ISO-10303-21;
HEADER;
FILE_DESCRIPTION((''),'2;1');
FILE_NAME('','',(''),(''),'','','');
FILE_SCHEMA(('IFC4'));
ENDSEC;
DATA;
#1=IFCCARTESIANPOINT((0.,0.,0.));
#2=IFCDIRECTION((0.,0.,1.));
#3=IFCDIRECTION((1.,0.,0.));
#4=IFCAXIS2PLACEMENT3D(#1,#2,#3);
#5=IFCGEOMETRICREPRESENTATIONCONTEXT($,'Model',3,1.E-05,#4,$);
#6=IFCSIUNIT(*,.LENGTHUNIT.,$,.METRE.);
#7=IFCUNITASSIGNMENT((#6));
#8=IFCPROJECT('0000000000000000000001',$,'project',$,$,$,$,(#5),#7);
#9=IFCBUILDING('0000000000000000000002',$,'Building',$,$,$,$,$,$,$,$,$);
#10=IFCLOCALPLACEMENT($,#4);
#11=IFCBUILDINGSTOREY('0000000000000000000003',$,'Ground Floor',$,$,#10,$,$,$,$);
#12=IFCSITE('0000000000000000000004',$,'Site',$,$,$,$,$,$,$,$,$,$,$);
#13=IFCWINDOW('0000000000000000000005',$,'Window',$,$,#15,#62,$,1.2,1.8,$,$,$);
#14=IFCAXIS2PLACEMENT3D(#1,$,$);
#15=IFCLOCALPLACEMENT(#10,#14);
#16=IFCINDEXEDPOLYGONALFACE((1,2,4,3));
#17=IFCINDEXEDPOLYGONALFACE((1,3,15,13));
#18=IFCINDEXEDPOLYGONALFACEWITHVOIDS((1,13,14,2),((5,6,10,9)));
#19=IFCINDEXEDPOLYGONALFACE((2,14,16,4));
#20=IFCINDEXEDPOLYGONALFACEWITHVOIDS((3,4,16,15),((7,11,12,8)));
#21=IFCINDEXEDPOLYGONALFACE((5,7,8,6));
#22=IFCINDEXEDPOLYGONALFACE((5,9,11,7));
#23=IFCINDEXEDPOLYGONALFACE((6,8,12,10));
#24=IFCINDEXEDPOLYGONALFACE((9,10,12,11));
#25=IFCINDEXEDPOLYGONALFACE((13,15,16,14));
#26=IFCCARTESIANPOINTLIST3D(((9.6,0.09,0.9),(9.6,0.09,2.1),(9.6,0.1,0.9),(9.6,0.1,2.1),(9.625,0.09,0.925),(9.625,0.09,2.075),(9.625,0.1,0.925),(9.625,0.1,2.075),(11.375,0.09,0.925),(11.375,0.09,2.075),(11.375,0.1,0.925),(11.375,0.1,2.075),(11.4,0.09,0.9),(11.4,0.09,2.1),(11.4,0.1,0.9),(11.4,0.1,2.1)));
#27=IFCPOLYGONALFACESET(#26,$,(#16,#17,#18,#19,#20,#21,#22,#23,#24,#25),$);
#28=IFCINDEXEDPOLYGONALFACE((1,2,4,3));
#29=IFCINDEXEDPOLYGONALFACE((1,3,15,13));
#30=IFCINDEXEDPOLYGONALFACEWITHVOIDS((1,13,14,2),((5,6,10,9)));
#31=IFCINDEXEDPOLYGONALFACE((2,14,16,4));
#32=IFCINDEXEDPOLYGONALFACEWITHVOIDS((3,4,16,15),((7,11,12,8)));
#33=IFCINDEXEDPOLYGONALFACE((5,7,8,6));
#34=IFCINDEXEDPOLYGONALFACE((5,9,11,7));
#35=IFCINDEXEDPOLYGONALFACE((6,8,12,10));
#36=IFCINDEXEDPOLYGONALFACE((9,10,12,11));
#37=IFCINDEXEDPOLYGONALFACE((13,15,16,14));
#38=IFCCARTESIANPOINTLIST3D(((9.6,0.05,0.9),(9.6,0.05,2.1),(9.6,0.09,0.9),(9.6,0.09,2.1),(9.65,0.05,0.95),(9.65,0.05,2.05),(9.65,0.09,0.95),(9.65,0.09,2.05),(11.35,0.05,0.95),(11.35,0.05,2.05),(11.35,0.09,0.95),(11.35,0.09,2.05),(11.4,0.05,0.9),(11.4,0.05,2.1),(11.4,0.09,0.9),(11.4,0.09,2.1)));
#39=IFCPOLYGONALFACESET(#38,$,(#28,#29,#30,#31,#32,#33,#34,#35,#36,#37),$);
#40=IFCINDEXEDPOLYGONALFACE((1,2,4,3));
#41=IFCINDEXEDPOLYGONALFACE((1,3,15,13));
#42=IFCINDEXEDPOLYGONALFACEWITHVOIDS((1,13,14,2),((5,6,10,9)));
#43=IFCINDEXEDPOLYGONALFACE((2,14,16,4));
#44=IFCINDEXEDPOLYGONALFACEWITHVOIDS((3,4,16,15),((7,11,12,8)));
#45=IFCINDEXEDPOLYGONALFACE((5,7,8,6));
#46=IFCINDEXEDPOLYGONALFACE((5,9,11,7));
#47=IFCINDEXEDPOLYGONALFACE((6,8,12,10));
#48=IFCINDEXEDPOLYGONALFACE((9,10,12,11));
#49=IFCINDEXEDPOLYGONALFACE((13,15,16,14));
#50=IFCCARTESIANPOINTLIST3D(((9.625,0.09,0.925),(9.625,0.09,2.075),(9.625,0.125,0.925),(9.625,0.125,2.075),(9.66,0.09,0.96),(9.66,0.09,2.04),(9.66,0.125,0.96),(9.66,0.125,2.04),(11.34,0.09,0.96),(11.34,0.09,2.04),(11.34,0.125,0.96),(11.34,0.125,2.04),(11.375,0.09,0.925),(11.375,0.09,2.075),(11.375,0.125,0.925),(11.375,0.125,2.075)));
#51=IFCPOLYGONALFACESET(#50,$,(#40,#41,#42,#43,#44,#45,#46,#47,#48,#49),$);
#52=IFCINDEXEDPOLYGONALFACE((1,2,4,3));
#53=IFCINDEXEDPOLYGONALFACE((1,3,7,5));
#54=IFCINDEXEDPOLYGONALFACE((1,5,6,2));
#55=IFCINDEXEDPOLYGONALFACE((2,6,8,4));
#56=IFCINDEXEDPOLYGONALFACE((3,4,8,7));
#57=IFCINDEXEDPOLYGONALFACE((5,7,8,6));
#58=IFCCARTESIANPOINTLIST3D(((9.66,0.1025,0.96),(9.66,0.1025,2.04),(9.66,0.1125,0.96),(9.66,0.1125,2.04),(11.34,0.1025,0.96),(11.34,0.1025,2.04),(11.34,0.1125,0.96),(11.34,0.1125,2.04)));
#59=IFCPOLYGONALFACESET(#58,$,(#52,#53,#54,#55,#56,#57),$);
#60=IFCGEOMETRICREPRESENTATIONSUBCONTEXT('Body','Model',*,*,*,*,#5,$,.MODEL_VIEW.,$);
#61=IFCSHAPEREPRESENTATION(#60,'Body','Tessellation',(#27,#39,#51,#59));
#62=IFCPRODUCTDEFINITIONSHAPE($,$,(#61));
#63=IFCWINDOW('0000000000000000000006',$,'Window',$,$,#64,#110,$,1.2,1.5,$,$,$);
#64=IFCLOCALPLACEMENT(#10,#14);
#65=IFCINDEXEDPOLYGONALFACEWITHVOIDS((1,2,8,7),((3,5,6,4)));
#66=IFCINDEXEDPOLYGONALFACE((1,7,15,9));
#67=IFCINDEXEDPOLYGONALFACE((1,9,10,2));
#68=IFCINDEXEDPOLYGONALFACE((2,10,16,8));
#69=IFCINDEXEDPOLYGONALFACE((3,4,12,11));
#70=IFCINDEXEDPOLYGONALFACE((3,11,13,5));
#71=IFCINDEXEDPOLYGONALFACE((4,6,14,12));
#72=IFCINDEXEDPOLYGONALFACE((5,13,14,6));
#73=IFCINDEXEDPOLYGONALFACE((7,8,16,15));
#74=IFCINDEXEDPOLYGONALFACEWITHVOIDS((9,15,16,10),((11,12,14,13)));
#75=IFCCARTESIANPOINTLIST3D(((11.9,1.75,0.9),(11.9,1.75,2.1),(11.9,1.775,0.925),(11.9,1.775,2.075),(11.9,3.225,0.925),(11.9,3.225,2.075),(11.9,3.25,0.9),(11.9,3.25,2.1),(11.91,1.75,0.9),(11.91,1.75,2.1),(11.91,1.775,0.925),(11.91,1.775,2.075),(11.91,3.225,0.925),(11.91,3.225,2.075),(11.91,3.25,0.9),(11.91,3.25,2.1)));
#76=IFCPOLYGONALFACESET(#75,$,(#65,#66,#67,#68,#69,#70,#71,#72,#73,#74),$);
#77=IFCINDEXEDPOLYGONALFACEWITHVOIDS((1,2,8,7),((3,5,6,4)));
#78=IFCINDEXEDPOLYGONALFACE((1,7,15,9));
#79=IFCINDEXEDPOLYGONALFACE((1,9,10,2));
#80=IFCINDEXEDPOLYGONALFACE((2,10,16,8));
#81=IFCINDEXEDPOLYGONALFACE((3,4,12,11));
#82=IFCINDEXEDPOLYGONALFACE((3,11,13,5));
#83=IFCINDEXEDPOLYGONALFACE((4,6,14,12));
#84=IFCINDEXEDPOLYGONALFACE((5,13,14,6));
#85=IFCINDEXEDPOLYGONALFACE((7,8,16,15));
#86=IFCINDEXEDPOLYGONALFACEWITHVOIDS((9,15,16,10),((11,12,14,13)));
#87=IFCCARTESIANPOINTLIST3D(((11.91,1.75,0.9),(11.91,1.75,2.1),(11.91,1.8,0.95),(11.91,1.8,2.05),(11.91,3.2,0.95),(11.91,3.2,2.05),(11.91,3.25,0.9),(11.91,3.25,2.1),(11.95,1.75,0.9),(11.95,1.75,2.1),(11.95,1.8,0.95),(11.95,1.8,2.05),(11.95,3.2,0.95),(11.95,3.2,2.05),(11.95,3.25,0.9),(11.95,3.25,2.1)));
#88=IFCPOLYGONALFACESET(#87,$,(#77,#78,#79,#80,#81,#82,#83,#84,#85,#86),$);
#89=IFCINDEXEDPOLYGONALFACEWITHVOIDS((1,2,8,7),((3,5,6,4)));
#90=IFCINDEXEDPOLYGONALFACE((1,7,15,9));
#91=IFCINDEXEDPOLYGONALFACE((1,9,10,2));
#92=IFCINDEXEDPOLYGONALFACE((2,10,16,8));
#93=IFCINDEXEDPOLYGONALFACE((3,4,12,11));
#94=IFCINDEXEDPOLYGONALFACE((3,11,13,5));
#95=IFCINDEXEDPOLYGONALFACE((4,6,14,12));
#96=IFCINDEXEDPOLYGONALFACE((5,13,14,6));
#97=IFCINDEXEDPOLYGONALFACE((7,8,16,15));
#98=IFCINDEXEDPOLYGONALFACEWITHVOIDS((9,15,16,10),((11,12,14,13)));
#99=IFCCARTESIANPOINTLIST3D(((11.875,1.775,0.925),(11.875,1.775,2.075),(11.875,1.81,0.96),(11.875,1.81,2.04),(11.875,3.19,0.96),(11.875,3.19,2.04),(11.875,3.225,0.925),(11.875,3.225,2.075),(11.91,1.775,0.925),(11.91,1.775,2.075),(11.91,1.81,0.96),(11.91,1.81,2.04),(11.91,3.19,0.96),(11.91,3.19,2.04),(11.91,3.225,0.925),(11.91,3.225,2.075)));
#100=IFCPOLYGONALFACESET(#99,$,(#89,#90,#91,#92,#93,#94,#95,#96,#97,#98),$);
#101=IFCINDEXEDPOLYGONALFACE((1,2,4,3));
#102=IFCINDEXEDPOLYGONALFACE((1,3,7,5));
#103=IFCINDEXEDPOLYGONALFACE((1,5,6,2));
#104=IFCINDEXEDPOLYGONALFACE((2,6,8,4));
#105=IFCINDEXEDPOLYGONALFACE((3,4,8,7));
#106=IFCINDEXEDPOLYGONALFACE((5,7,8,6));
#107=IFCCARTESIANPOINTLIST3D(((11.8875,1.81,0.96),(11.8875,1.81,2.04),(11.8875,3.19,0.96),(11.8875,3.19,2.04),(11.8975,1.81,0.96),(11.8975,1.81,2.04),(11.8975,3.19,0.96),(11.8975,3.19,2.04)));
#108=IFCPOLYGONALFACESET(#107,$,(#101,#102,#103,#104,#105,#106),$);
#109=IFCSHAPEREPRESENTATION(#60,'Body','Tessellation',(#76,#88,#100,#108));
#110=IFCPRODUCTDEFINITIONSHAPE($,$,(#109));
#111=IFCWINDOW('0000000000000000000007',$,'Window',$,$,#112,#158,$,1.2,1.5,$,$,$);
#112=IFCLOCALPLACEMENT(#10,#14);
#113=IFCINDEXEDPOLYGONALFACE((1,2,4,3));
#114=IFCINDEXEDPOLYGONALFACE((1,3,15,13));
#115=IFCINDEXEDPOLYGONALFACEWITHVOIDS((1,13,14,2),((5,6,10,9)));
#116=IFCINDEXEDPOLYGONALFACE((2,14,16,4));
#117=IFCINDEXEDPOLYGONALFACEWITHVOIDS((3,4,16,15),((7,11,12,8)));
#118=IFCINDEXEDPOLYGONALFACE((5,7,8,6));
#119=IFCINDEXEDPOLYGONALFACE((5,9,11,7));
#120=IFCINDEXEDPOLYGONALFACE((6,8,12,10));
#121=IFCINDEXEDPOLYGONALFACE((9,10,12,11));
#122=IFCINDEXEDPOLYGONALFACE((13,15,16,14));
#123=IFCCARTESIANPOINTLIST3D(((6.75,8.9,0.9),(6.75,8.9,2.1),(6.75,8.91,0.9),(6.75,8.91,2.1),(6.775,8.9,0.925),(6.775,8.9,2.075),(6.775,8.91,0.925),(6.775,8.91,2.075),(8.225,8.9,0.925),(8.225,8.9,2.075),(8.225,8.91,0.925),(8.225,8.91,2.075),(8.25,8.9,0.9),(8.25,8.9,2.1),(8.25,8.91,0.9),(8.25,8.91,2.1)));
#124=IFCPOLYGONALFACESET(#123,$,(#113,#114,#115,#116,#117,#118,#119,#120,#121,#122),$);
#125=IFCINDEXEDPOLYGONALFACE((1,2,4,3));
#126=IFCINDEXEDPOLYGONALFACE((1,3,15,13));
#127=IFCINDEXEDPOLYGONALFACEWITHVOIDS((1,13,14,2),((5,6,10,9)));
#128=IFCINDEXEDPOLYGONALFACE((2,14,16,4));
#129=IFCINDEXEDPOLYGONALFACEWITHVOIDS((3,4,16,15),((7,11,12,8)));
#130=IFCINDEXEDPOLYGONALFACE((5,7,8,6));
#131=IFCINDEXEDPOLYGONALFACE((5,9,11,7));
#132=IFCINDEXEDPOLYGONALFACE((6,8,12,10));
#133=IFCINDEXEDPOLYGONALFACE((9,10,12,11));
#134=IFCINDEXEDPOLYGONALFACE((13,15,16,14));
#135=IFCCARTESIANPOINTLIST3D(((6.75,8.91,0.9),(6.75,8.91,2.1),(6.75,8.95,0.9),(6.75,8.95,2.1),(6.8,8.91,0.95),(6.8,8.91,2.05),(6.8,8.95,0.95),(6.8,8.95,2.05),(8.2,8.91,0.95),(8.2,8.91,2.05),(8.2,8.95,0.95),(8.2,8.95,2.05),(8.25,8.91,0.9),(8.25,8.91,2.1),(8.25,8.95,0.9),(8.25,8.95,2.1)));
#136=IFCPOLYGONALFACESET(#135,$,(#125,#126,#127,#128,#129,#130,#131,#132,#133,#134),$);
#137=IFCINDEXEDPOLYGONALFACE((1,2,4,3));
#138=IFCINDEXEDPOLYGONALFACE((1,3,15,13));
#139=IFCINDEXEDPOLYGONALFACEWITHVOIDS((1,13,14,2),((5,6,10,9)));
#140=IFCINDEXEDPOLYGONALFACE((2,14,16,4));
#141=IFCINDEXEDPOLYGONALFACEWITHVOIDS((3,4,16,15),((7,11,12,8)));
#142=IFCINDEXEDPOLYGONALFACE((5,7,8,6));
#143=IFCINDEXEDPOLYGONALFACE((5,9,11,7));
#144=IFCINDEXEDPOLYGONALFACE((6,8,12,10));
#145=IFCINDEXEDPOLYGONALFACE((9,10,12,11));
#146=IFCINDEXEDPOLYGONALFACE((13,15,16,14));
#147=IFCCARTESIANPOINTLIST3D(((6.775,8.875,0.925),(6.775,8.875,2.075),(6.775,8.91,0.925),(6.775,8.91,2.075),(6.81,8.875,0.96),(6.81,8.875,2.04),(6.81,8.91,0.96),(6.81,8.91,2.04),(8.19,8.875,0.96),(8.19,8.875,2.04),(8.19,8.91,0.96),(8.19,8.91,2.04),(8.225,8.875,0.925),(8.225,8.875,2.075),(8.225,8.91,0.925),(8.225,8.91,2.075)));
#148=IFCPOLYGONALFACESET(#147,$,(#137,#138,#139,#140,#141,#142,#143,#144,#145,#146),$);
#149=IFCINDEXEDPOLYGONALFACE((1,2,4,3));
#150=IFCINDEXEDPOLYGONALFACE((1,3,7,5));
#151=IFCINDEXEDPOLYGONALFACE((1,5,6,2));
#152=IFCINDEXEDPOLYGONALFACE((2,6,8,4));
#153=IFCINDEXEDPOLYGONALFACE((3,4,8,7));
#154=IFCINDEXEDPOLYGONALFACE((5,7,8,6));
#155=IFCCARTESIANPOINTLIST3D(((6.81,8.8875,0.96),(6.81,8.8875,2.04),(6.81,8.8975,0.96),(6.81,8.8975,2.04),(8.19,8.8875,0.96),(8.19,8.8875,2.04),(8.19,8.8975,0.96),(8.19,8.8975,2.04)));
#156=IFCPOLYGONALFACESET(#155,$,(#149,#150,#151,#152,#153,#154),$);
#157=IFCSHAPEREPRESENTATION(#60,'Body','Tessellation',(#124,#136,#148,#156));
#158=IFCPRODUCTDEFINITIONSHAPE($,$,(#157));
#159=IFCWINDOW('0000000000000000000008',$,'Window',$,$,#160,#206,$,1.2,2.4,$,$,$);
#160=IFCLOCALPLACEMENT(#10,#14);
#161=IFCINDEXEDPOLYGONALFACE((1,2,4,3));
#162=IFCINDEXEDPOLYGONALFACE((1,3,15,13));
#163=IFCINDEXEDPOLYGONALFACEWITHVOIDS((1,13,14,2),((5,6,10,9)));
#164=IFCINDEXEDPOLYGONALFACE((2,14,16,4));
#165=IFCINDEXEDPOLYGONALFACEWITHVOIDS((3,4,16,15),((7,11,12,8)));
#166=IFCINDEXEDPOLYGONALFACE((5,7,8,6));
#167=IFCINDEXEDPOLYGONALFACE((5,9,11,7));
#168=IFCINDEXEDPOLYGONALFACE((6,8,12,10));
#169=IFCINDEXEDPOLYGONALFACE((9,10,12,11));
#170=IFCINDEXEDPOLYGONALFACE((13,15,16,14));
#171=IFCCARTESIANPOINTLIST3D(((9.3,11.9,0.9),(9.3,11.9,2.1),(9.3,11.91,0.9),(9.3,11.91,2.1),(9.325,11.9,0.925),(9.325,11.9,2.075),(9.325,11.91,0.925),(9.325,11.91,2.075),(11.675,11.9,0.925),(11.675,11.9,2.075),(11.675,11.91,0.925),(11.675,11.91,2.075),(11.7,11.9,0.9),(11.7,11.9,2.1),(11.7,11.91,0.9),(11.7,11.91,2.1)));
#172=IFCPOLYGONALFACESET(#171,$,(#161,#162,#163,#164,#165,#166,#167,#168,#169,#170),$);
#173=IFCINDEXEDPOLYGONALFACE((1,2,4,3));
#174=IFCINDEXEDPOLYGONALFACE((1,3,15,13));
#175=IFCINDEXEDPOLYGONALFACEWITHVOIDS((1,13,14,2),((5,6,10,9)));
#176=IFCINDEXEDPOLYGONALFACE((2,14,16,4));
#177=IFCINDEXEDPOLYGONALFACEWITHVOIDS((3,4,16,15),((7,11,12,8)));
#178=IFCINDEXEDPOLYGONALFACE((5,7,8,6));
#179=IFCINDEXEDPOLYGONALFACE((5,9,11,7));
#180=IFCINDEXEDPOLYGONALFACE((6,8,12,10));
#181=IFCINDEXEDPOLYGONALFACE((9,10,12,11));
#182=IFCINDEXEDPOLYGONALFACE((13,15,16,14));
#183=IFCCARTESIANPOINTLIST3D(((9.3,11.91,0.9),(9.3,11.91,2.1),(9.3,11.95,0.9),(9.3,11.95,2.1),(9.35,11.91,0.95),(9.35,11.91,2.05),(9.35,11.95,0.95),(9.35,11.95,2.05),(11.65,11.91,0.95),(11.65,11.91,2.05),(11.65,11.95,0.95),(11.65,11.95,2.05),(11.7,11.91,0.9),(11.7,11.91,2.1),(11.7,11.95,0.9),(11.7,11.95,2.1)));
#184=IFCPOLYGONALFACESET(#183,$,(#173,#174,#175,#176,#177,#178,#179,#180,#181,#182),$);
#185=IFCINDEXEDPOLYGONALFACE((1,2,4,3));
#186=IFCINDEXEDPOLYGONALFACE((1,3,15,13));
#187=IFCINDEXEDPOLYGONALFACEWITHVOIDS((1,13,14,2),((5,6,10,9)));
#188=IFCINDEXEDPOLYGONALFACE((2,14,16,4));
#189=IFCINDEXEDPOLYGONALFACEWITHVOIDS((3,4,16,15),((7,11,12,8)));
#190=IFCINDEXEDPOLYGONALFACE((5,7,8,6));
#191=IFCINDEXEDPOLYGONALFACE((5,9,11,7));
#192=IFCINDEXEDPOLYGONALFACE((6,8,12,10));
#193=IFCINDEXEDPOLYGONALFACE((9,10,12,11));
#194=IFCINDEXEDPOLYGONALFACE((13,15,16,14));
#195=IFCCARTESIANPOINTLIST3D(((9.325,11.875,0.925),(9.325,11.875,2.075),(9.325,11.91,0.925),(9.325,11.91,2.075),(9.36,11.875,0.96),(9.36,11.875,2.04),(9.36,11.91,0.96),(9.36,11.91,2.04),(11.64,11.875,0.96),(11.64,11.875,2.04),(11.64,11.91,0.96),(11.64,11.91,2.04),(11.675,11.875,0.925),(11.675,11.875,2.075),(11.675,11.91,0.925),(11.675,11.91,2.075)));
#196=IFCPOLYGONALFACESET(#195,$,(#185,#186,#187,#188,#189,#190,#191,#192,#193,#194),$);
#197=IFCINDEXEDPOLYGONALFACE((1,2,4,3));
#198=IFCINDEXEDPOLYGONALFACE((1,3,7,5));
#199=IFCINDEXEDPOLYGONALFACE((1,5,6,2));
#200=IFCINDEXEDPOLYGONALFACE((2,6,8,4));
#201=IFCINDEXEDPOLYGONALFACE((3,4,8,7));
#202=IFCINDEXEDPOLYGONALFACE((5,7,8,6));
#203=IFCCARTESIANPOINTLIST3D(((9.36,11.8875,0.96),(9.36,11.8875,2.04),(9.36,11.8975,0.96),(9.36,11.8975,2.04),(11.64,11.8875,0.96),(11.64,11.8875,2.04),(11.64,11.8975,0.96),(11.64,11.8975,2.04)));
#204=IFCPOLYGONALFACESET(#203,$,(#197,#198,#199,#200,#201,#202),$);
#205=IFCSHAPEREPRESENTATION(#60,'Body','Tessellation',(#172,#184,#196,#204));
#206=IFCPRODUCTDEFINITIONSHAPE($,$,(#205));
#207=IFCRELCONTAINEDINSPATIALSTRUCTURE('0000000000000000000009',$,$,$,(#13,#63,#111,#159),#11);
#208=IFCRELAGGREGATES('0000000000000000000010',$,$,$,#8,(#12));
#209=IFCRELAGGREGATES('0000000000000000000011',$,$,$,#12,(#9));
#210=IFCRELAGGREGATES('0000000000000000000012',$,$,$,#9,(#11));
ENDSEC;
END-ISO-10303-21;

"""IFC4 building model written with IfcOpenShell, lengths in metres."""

from ifc_helpers import new_model, si_unit, frame, origin_with_axes, place, context, subcontext, project, spatial, line, indexed_curve, outline, extrude, element, save


model = new_model("IFC4")

# Units and contexts
model_context = context("Model", 3, precision=1e-05, world=origin_with_axes())
body_context = subcontext(model_context, "Body", "Model", "MODEL_VIEW")
ifc_project = project(units=[si_unit("LENGTHUNIT", "METRE")], contexts=[model_context])

# Site, building, storey
site = spatial("IfcSite", under=ifc_project, Name="Site")
building = spatial("IfcBuilding", under=site, Name="Building")
storey_placement = place(None, origin_with_axes())
storey = spatial("IfcBuildingStorey", under=building, at=storey_placement, Name="Ground Floor")

# Windows
window_1_placement = place(storey_placement, frame((9.6, 0.0, 0.9), z_axis=(0.0, 0.0, 1.0), x_axis=(1.0, 0.0, 0.0)))
element("IfcWindow", 1, at=window_1_placement, inside=storey, Name="Window", OverallHeight=1.2, OverallWidth=1.8, context=body_context, shape_type="SweptSolid", body=[
    extrude(outline(indexed_curve([(0.0, 0.0), (1.8, 0.0), (1.8, 1.2), (0.0, 1.2)], segments=[line(1, 2, 3, 4, 1)]), holes=[indexed_curve([(0.025, 0.025), (1.775, 0.025), (1.775, 1.175), (0.025, 1.175)], segments=[line(1, 2, 3, 4, 1)])]), frame((0.0, 0.09, 0.0), z_axis=(0.0, -1.0, 0.0), x_axis=(1.0, 0.0, 0.0)), (0.0, 0.0, -1.0), 0.01),
    extrude(outline(indexed_curve([(0.0, 0.0), (1.8, 0.0), (1.8, 1.2), (0.0, 1.2)], segments=[line(1, 2, 3, 4, 1)]), holes=[indexed_curve([(0.05, 0.05), (1.75, 0.05), (1.75, 1.15), (0.05, 1.15)], segments=[line(1, 2, 3, 4, 1)])]), frame((0.0, 0.05, 0.0), z_axis=(0.0, -1.0, 0.0), x_axis=(1.0, 0.0, 0.0)), (0.0, 0.0, -1.0), 0.04),
    extrude(outline(indexed_curve([(0.0, 0.0), (1.75, 0.0), (1.75, 1.15), (0.0, 1.15)], segments=[line(1, 2, 3, 4, 1)]), holes=[indexed_curve([(0.035, 0.035), (1.715, 0.035), (1.715, 1.115), (0.035, 1.115)], segments=[line(1, 2, 3, 4, 1)])]), frame((0.025, 0.09, 0.025), z_axis=(0.0, -1.0, 0.0), x_axis=(1.0, 0.0, 0.0)), (0.0, 0.0, -1.0), 0.035),
    extrude(outline(indexed_curve([(0.035, 0.035), (1.715, 0.035), (1.715, 1.115), (0.035, 1.115)], segments=[line(1, 2, 3, 4, 1)])), frame((0.025, 0.1025, 0.025), z_axis=(0.0, -1.0, 0.0), x_axis=(1.0, 0.0, 0.0)), (0.0, 0.0, -1.0), 0.01),
])
for number, where, z_axis, x_axis, name in (
    (2, (12.0, 1.75, 0.9), (0.0, 0.0, 1.0), (0.0, 1.0, 0.0), "Window"),
    (3, (8.25, 9.0, 0.9), (0.0, 0.0, 1.0), (-1.0, 0.0, 0.0), "Window"),
):
    element("IfcWindow", number, at=place(storey_placement, frame(where, z_axis=z_axis, x_axis=x_axis)), inside=storey, Name=name, OverallHeight=1.2, OverallWidth=1.5, context=body_context, shape_type="SweptSolid", body=[
        extrude(outline(indexed_curve([(0.0, 0.0), (1.5, 0.0), (1.5, 1.2), (0.0, 1.2)], segments=[line(1, 2, 3, 4, 1)]), holes=[indexed_curve([(0.025, 0.025), (1.475, 0.025), (1.475, 1.175), (0.025, 1.175)], segments=[line(1, 2, 3, 4, 1)])]), frame((0.0, 0.09, 0.0), z_axis=(0.0, -1.0, 0.0), x_axis=(1.0, 0.0, 0.0)), (0.0, 0.0, -1.0), 0.01),
        extrude(outline(indexed_curve([(0.0, 0.0), (1.5, 0.0), (1.5, 1.2), (0.0, 1.2)], segments=[line(1, 2, 3, 4, 1)]), holes=[indexed_curve([(0.05, 0.05), (1.45, 0.05), (1.45, 1.15), (0.05, 1.15)], segments=[line(1, 2, 3, 4, 1)])]), frame((0.0, 0.05, 0.0), z_axis=(0.0, -1.0, 0.0), x_axis=(1.0, 0.0, 0.0)), (0.0, 0.0, -1.0), 0.04),
        extrude(outline(indexed_curve([(0.0, 0.0), (1.45, 0.0), (1.45, 1.15), (0.0, 1.15)], segments=[line(1, 2, 3, 4, 1)]), holes=[indexed_curve([(0.035, 0.035), (1.415, 0.035), (1.415, 1.115), (0.035, 1.115)], segments=[line(1, 2, 3, 4, 1)])]), frame((0.025, 0.09, 0.025), z_axis=(0.0, -1.0, 0.0), x_axis=(1.0, 0.0, 0.0)), (0.0, 0.0, -1.0), 0.035),
        extrude(outline(indexed_curve([(0.035, 0.035), (1.415, 0.035), (1.415, 1.115), (0.035, 1.115)], segments=[line(1, 2, 3, 4, 1)])), frame((0.025, 0.1025, 0.025), z_axis=(0.0, -1.0, 0.0), x_axis=(1.0, 0.0, 0.0)), (0.0, 0.0, -1.0), 0.01),
    ])
window_2_placement = place(storey_placement, frame((11.7, 12.0, 0.9), z_axis=(0.0, 0.0, 1.0), x_axis=(-1.0, 0.0, 0.0)))
element("IfcWindow", 4, at=window_2_placement, inside=storey, Name="Window", OverallHeight=1.2, OverallWidth=2.4, context=body_context, shape_type="SweptSolid", body=[
    extrude(outline(indexed_curve([(0.0, 0.0), (2.4, 0.0), (2.4, 1.2), (0.0, 1.2)], segments=[line(1, 2, 3, 4, 1)]), holes=[indexed_curve([(0.025, 0.025), (2.375, 0.025), (2.375, 1.175), (0.025, 1.175)], segments=[line(1, 2, 3, 4, 1)])]), frame((0.0, 0.09, 0.0), z_axis=(0.0, -1.0, 0.0), x_axis=(1.0, 0.0, 0.0)), (0.0, 0.0, -1.0), 0.01),
    extrude(outline(indexed_curve([(0.0, 0.0), (2.4, 0.0), (2.4, 1.2), (0.0, 1.2)], segments=[line(1, 2, 3, 4, 1)]), holes=[indexed_curve([(0.05, 0.05), (2.35, 0.05), (2.35, 1.15), (0.05, 1.15)], segments=[line(1, 2, 3, 4, 1)])]), frame((0.0, 0.05, 0.0), z_axis=(0.0, -1.0, 0.0), x_axis=(1.0, 0.0, 0.0)), (0.0, 0.0, -1.0), 0.04),
    extrude(outline(indexed_curve([(0.0, 0.0), (2.35, 0.0), (2.35, 1.15), (0.0, 1.15)], segments=[line(1, 2, 3, 4, 1)]), holes=[indexed_curve([(0.035, 0.035), (2.315, 0.035), (2.315, 1.115), (0.035, 1.115)], segments=[line(1, 2, 3, 4, 1)])]), frame((0.025, 0.09, 0.025), z_axis=(0.0, -1.0, 0.0), x_axis=(1.0, 0.0, 0.0)), (0.0, 0.0, -1.0), 0.035),
    extrude(outline(indexed_curve([(0.035, 0.035), (2.315, 0.035), (2.315, 1.115), (0.035, 1.115)], segments=[line(1, 2, 3, 4, 1)])), frame((0.025, 0.1025, 0.025), z_axis=(0.0, -1.0, 0.0), x_axis=(1.0, 0.0, 0.0)), (0.0, 0.0, -1.0), 0.01),
])

save(model, "model.ifc")
